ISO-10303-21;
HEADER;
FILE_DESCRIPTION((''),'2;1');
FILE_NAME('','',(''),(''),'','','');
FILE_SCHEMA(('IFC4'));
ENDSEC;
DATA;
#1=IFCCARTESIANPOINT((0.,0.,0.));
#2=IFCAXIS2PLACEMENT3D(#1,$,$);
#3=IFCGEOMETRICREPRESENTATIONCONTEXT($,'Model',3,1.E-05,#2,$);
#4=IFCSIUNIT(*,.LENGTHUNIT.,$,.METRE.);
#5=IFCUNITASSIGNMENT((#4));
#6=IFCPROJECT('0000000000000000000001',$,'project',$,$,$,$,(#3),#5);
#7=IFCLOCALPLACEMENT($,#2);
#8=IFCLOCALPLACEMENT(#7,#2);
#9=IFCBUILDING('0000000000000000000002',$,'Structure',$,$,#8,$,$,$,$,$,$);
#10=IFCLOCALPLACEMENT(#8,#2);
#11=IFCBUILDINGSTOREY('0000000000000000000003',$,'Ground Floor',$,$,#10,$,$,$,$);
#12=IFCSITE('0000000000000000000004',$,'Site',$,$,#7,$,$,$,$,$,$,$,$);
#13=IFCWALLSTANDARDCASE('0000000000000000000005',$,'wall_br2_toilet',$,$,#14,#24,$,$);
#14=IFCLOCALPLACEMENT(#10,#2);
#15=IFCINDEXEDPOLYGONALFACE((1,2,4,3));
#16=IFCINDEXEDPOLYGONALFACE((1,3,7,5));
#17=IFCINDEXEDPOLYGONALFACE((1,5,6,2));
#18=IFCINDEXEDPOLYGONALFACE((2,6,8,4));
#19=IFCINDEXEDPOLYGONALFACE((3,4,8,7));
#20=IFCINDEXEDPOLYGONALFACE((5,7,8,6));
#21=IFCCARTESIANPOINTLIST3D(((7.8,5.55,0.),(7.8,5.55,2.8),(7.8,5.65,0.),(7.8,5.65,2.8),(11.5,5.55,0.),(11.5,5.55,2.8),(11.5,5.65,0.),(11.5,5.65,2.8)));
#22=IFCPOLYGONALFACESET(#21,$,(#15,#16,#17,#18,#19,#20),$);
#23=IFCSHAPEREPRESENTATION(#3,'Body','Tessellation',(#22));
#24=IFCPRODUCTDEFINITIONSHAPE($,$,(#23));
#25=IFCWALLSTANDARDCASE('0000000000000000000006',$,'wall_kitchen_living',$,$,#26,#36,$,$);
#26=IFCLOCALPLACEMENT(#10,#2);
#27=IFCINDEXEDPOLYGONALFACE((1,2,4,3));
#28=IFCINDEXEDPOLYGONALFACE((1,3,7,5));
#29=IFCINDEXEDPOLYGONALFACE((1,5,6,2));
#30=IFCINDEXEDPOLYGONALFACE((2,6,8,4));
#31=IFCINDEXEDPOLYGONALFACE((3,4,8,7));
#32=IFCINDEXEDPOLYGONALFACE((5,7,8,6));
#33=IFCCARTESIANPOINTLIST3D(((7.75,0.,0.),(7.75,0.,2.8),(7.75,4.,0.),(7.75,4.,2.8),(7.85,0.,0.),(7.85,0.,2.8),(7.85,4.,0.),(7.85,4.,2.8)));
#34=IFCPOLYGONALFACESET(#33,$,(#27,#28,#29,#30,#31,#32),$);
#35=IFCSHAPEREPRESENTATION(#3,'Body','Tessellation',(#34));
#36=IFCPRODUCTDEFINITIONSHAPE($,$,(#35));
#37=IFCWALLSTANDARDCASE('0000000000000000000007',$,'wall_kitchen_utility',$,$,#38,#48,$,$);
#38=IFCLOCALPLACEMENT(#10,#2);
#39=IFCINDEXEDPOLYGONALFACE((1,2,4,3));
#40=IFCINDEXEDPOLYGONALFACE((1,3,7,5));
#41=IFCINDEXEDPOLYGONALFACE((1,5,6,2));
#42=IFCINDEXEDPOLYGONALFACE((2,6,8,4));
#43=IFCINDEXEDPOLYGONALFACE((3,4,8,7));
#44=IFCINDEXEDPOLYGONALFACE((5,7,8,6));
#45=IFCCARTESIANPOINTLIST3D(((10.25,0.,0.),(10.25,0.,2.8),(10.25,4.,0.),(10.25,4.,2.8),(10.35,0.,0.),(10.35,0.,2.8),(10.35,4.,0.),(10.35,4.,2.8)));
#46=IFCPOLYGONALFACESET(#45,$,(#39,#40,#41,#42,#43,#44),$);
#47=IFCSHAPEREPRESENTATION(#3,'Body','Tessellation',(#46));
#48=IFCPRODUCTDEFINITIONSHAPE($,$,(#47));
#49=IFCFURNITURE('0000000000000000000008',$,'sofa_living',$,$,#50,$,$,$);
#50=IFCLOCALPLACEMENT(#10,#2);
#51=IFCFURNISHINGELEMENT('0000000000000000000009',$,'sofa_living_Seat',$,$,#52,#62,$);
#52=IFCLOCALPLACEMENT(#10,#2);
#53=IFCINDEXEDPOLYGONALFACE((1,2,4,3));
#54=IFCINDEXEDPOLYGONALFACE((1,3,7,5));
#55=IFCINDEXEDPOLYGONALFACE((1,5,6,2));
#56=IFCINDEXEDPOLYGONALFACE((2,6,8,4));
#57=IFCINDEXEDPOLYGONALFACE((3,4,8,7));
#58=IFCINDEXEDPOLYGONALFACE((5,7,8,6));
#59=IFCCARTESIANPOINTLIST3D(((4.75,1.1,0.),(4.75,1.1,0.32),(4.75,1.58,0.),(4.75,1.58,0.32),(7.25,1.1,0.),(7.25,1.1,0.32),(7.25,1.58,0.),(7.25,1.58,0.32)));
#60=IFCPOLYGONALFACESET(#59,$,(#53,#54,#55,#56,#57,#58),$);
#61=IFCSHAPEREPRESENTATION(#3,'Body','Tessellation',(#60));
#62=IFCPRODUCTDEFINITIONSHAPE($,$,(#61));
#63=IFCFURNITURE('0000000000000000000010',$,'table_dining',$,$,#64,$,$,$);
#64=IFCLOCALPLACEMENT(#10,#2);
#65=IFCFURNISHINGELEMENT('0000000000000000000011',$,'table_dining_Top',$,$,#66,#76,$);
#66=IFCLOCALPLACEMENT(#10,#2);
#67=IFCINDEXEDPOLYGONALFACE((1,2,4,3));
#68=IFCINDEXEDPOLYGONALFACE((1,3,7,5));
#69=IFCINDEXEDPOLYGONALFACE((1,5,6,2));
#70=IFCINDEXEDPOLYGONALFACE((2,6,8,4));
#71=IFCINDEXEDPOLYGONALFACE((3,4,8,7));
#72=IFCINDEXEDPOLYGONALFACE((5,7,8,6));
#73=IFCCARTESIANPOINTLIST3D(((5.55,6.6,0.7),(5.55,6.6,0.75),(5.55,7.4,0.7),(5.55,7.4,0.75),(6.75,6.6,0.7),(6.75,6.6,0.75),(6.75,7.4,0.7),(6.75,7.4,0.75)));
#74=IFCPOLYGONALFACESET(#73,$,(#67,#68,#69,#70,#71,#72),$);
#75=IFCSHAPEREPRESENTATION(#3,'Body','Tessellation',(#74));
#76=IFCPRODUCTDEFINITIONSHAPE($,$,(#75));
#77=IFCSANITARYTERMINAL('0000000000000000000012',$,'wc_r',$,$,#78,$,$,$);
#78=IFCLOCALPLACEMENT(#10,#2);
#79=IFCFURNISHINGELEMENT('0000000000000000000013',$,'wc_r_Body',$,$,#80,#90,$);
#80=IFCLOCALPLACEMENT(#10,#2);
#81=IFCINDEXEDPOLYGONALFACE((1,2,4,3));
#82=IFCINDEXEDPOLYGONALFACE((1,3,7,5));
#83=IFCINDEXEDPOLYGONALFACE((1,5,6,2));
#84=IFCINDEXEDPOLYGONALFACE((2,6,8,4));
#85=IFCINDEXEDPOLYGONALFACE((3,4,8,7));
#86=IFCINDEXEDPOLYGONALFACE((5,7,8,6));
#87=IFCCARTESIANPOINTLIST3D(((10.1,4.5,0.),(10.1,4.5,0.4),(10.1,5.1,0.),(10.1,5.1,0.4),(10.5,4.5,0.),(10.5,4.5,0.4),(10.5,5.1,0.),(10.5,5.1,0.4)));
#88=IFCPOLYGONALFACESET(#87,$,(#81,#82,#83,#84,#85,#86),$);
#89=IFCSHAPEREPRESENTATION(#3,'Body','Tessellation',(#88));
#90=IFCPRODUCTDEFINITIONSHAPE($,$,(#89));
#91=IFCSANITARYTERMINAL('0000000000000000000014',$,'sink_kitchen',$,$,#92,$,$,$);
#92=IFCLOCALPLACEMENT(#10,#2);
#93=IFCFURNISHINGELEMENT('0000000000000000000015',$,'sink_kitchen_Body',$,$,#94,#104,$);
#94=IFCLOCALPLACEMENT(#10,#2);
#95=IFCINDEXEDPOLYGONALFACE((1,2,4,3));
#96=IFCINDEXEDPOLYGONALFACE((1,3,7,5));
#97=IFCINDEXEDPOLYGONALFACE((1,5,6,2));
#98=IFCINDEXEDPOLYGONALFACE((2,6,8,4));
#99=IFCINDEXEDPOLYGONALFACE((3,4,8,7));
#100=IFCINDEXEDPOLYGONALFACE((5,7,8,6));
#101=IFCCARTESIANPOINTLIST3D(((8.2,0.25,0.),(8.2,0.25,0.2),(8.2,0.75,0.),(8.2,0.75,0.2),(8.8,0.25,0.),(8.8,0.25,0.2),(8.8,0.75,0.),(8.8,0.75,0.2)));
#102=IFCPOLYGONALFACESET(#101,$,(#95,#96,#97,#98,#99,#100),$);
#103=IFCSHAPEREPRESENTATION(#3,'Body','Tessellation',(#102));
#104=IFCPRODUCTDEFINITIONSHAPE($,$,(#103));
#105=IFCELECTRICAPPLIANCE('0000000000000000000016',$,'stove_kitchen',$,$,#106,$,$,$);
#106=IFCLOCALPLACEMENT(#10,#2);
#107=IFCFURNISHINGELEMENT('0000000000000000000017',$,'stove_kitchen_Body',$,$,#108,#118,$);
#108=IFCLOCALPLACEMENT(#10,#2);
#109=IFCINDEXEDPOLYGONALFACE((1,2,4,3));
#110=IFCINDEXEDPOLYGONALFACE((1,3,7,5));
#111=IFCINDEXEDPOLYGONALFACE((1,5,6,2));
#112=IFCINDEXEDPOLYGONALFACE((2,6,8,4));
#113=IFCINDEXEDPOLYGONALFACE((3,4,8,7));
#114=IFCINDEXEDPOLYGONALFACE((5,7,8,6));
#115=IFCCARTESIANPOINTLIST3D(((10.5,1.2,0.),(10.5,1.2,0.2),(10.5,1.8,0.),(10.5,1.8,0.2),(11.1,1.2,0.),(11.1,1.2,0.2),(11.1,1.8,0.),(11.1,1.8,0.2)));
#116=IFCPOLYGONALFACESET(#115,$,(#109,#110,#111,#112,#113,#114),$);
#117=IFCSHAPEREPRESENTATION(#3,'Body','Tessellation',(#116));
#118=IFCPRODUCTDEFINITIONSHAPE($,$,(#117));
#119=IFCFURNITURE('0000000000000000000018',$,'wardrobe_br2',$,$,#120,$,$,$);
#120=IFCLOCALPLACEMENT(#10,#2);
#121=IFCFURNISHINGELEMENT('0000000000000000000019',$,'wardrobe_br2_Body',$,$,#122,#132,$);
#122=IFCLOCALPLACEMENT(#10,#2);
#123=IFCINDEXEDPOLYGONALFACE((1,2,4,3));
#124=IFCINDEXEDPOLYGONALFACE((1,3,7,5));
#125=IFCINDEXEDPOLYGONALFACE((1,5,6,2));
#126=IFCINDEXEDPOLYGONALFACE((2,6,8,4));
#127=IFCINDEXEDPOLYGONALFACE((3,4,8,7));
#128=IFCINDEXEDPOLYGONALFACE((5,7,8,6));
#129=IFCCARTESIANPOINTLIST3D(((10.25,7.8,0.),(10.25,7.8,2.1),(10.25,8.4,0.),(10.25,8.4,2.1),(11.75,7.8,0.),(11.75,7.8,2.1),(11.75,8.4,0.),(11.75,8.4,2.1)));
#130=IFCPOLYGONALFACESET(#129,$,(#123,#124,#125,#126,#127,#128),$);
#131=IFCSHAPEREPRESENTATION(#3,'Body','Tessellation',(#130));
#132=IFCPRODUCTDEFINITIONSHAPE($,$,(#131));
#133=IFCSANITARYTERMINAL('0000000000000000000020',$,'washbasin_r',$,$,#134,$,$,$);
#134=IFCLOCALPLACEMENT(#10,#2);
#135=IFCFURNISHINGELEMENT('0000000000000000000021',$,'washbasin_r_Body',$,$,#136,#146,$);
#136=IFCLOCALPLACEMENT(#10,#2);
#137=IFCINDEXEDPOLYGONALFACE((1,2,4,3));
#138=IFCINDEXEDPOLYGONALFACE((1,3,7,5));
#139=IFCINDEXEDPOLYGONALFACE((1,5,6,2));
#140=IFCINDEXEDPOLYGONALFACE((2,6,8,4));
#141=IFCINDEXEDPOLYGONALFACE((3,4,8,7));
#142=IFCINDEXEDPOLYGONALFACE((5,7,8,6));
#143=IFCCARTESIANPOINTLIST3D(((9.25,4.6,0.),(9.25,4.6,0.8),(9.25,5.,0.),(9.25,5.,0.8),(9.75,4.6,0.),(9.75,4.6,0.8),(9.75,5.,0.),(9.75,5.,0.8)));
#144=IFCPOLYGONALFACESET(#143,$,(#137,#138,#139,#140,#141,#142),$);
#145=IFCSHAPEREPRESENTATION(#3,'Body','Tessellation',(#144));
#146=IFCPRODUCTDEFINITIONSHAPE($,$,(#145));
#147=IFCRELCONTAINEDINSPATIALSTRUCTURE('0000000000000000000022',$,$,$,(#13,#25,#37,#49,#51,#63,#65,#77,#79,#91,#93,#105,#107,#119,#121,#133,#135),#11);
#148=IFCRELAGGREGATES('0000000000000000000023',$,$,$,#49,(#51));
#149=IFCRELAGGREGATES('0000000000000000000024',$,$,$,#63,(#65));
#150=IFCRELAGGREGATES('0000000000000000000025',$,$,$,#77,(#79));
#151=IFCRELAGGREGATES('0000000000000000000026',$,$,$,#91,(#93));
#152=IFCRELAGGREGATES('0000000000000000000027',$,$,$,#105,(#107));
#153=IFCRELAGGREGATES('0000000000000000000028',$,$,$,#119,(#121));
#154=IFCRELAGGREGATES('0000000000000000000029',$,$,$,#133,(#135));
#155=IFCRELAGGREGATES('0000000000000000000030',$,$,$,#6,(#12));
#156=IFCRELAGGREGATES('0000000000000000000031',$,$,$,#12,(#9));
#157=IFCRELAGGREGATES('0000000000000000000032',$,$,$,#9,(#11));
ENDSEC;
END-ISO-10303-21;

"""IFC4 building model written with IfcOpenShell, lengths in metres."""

from ifc_helpers import new_model, si_unit, frame, origin, origin_2d, place, context, project, spatial, rectangle, extrude, element, aggregate, save


model = new_model("IFC4")

# Units and contexts
model_context = context("Model", 3, precision=1e-05, world=origin())
ifc_project = project(units=[si_unit("LENGTHUNIT", "METRE")], contexts=[model_context])

# Site, building, storey
site_placement = place(None, origin())
site = spatial("IfcSite", under=ifc_project, at=site_placement, Name="Site")
building_placement = place(site_placement, origin())
building = spatial("IfcBuilding", under=site, at=building_placement, Name="Structure")
storey_placement = place(building_placement, origin())
storey = spatial("IfcBuildingStorey", under=building, at=storey_placement, Name="Ground Floor")

# Walls
wall_placement = place(storey_placement, frame((7.8, 5.6, 0.0), x_axis=(1.0, 0.0, 0.0)))
element("IfcWallStandardCase", 1, at=wall_placement, inside=storey, Name="wall_br2_toilet", context=model_context, shape_type="SweptSolid", body=[
    extrude(rectangle(XDim=3.7, YDim=0.1, at=origin_2d()), frame((1.85, 0.0, 0.0)), (0.0, 0.0, 1.0), 2.8),
])
for number, where, x_axis, name in (
    (2, (7.8, 0.0, 0.0), (0.0, 1.0, 0.0), "wall_kitchen_living"),
    (3, (10.3, 0.0, 0.0), (0.0, 1.0, 0.0), "wall_kitchen_utility"),
):
    element("IfcWallStandardCase", number, at=place(storey_placement, frame(where, x_axis=x_axis)), inside=storey, Name=name, context=model_context, shape_type="SweptSolid", body=[
        extrude(rectangle(XDim=4.0, YDim=0.1, at=origin_2d()), frame((2.0, 0.0, 0.0)), (0.0, 0.0, 1.0), 2.8),
    ])

# Furniture, furnishing elements
furniture_1_placement = place(storey_placement, frame((6.0, 1.5, 0.0)))
furniture_1 = element("IfcFurniture", 4, at=furniture_1_placement, inside=storey, Name="sofa_living")
furnishing_1_placement = place(furniture_1_placement, origin())
furnishing_1 = element("IfcFurnishingElement", 5, at=furnishing_1_placement, inside=storey, Name="sofa_living_Seat", context=model_context, shape_type="SweptSolid", body=[
    extrude(rectangle(XDim=2.5, YDim=0.48, at=origin_2d()), frame((0.0, -0.16, 0.0)), (0.0, 0.0, 1.0), 0.32),
])
aggregate(furniture_1, [furnishing_1])
furniture_2_placement = place(storey_placement, frame((6.15, 7.0, 0.0)))
furniture_2 = element("IfcFurniture", 6, at=furniture_2_placement, inside=storey, Name="table_dining")
furnishing_2_placement = place(furniture_2_placement, origin())
furnishing_2 = element("IfcFurnishingElement", 7, at=furnishing_2_placement, inside=storey, Name="table_dining_Top", context=model_context, shape_type="SweptSolid", body=[
    extrude(rectangle(XDim=1.2, YDim=0.8, at=origin_2d()), frame((0.0, 0.0, 0.7)), (0.0, 0.0, 1.0), 0.05),
])
aggregate(furniture_2, [furnishing_2])

# Sanitary terminals, furnishing elements
sanitary_terminal_1_placement = place(storey_placement, frame((10.3, 4.8, 0.0)))
sanitary_terminal_1 = element("IfcSanitaryTerminal", 8, at=sanitary_terminal_1_placement, inside=storey, Name="wc_r")
furnishing_3_placement = place(sanitary_terminal_1_placement, origin())
furnishing_3 = element("IfcFurnishingElement", 9, at=furnishing_3_placement, inside=storey, Name="wc_r_Body", context=model_context, shape_type="SweptSolid", body=[
    extrude(rectangle(XDim=0.4, YDim=0.6, at=origin_2d()), origin(), (0.0, 0.0, 1.0), 0.4),
])
aggregate(sanitary_terminal_1, [furnishing_3])
sanitary_terminal_2_placement = place(storey_placement, frame((8.5, 0.5, 0.0)))
sanitary_terminal_2 = element("IfcSanitaryTerminal", 10, at=sanitary_terminal_2_placement, inside=storey, Name="sink_kitchen")
furnishing_4_placement = place(sanitary_terminal_2_placement, origin())
furnishing_4 = element("IfcFurnishingElement", 11, at=furnishing_4_placement, inside=storey, Name="sink_kitchen_Body", context=model_context, shape_type="SweptSolid", body=[
    extrude(rectangle(XDim=0.6, YDim=0.5, at=origin_2d()), origin(), (0.0, 0.0, 1.0), 0.2),
])
aggregate(sanitary_terminal_2, [furnishing_4])

# Electric appliance, furnishing element
electric_appliance_placement = place(storey_placement, frame((10.8, 1.5, 0.0)))
electric_appliance = element("IfcElectricAppliance", 12, at=electric_appliance_placement, inside=storey, Name="stove_kitchen")
furnishing_5_placement = place(electric_appliance_placement, origin())
furnishing_5 = element("IfcFurnishingElement", 13, at=furnishing_5_placement, inside=storey, Name="stove_kitchen_Body", context=model_context, shape_type="SweptSolid", body=[
    extrude(rectangle(XDim=0.6, YDim=0.6, at=origin_2d()), origin(), (0.0, 0.0, 1.0), 0.2),
])
aggregate(electric_appliance, [furnishing_5])

# Furniture, furnishing element
furniture_3_placement = place(storey_placement, frame((11.0, 8.1, 0.0)))
furniture_3 = element("IfcFurniture", 14, at=furniture_3_placement, inside=storey, Name="wardrobe_br2")
furnishing_6_placement = place(furniture_3_placement, origin())
furnishing_6 = element("IfcFurnishingElement", 15, at=furnishing_6_placement, inside=storey, Name="wardrobe_br2_Body", context=model_context, shape_type="SweptSolid", body=[
    extrude(rectangle(XDim=1.5, YDim=0.6, at=origin_2d()), origin(), (0.0, 0.0, 1.0), 2.1),
])
aggregate(furniture_3, [furnishing_6])

# Sanitary terminal, furnishing element
sanitary_terminal_3_placement = place(storey_placement, frame((9.5, 4.8, 0.0)))
sanitary_terminal_3 = element("IfcSanitaryTerminal", 16, at=sanitary_terminal_3_placement, inside=storey, Name="washbasin_r")
furnishing_7_placement = place(sanitary_terminal_3_placement, origin())
furnishing_7 = element("IfcFurnishingElement", 17, at=furnishing_7_placement, inside=storey, Name="washbasin_r_Body", context=model_context, shape_type="SweptSolid", body=[
    extrude(rectangle(XDim=0.5, YDim=0.4, at=origin_2d()), origin(), (0.0, 0.0, 1.0), 0.8),
])
aggregate(sanitary_terminal_3, [furnishing_7])

save(model, "model.ifc")
